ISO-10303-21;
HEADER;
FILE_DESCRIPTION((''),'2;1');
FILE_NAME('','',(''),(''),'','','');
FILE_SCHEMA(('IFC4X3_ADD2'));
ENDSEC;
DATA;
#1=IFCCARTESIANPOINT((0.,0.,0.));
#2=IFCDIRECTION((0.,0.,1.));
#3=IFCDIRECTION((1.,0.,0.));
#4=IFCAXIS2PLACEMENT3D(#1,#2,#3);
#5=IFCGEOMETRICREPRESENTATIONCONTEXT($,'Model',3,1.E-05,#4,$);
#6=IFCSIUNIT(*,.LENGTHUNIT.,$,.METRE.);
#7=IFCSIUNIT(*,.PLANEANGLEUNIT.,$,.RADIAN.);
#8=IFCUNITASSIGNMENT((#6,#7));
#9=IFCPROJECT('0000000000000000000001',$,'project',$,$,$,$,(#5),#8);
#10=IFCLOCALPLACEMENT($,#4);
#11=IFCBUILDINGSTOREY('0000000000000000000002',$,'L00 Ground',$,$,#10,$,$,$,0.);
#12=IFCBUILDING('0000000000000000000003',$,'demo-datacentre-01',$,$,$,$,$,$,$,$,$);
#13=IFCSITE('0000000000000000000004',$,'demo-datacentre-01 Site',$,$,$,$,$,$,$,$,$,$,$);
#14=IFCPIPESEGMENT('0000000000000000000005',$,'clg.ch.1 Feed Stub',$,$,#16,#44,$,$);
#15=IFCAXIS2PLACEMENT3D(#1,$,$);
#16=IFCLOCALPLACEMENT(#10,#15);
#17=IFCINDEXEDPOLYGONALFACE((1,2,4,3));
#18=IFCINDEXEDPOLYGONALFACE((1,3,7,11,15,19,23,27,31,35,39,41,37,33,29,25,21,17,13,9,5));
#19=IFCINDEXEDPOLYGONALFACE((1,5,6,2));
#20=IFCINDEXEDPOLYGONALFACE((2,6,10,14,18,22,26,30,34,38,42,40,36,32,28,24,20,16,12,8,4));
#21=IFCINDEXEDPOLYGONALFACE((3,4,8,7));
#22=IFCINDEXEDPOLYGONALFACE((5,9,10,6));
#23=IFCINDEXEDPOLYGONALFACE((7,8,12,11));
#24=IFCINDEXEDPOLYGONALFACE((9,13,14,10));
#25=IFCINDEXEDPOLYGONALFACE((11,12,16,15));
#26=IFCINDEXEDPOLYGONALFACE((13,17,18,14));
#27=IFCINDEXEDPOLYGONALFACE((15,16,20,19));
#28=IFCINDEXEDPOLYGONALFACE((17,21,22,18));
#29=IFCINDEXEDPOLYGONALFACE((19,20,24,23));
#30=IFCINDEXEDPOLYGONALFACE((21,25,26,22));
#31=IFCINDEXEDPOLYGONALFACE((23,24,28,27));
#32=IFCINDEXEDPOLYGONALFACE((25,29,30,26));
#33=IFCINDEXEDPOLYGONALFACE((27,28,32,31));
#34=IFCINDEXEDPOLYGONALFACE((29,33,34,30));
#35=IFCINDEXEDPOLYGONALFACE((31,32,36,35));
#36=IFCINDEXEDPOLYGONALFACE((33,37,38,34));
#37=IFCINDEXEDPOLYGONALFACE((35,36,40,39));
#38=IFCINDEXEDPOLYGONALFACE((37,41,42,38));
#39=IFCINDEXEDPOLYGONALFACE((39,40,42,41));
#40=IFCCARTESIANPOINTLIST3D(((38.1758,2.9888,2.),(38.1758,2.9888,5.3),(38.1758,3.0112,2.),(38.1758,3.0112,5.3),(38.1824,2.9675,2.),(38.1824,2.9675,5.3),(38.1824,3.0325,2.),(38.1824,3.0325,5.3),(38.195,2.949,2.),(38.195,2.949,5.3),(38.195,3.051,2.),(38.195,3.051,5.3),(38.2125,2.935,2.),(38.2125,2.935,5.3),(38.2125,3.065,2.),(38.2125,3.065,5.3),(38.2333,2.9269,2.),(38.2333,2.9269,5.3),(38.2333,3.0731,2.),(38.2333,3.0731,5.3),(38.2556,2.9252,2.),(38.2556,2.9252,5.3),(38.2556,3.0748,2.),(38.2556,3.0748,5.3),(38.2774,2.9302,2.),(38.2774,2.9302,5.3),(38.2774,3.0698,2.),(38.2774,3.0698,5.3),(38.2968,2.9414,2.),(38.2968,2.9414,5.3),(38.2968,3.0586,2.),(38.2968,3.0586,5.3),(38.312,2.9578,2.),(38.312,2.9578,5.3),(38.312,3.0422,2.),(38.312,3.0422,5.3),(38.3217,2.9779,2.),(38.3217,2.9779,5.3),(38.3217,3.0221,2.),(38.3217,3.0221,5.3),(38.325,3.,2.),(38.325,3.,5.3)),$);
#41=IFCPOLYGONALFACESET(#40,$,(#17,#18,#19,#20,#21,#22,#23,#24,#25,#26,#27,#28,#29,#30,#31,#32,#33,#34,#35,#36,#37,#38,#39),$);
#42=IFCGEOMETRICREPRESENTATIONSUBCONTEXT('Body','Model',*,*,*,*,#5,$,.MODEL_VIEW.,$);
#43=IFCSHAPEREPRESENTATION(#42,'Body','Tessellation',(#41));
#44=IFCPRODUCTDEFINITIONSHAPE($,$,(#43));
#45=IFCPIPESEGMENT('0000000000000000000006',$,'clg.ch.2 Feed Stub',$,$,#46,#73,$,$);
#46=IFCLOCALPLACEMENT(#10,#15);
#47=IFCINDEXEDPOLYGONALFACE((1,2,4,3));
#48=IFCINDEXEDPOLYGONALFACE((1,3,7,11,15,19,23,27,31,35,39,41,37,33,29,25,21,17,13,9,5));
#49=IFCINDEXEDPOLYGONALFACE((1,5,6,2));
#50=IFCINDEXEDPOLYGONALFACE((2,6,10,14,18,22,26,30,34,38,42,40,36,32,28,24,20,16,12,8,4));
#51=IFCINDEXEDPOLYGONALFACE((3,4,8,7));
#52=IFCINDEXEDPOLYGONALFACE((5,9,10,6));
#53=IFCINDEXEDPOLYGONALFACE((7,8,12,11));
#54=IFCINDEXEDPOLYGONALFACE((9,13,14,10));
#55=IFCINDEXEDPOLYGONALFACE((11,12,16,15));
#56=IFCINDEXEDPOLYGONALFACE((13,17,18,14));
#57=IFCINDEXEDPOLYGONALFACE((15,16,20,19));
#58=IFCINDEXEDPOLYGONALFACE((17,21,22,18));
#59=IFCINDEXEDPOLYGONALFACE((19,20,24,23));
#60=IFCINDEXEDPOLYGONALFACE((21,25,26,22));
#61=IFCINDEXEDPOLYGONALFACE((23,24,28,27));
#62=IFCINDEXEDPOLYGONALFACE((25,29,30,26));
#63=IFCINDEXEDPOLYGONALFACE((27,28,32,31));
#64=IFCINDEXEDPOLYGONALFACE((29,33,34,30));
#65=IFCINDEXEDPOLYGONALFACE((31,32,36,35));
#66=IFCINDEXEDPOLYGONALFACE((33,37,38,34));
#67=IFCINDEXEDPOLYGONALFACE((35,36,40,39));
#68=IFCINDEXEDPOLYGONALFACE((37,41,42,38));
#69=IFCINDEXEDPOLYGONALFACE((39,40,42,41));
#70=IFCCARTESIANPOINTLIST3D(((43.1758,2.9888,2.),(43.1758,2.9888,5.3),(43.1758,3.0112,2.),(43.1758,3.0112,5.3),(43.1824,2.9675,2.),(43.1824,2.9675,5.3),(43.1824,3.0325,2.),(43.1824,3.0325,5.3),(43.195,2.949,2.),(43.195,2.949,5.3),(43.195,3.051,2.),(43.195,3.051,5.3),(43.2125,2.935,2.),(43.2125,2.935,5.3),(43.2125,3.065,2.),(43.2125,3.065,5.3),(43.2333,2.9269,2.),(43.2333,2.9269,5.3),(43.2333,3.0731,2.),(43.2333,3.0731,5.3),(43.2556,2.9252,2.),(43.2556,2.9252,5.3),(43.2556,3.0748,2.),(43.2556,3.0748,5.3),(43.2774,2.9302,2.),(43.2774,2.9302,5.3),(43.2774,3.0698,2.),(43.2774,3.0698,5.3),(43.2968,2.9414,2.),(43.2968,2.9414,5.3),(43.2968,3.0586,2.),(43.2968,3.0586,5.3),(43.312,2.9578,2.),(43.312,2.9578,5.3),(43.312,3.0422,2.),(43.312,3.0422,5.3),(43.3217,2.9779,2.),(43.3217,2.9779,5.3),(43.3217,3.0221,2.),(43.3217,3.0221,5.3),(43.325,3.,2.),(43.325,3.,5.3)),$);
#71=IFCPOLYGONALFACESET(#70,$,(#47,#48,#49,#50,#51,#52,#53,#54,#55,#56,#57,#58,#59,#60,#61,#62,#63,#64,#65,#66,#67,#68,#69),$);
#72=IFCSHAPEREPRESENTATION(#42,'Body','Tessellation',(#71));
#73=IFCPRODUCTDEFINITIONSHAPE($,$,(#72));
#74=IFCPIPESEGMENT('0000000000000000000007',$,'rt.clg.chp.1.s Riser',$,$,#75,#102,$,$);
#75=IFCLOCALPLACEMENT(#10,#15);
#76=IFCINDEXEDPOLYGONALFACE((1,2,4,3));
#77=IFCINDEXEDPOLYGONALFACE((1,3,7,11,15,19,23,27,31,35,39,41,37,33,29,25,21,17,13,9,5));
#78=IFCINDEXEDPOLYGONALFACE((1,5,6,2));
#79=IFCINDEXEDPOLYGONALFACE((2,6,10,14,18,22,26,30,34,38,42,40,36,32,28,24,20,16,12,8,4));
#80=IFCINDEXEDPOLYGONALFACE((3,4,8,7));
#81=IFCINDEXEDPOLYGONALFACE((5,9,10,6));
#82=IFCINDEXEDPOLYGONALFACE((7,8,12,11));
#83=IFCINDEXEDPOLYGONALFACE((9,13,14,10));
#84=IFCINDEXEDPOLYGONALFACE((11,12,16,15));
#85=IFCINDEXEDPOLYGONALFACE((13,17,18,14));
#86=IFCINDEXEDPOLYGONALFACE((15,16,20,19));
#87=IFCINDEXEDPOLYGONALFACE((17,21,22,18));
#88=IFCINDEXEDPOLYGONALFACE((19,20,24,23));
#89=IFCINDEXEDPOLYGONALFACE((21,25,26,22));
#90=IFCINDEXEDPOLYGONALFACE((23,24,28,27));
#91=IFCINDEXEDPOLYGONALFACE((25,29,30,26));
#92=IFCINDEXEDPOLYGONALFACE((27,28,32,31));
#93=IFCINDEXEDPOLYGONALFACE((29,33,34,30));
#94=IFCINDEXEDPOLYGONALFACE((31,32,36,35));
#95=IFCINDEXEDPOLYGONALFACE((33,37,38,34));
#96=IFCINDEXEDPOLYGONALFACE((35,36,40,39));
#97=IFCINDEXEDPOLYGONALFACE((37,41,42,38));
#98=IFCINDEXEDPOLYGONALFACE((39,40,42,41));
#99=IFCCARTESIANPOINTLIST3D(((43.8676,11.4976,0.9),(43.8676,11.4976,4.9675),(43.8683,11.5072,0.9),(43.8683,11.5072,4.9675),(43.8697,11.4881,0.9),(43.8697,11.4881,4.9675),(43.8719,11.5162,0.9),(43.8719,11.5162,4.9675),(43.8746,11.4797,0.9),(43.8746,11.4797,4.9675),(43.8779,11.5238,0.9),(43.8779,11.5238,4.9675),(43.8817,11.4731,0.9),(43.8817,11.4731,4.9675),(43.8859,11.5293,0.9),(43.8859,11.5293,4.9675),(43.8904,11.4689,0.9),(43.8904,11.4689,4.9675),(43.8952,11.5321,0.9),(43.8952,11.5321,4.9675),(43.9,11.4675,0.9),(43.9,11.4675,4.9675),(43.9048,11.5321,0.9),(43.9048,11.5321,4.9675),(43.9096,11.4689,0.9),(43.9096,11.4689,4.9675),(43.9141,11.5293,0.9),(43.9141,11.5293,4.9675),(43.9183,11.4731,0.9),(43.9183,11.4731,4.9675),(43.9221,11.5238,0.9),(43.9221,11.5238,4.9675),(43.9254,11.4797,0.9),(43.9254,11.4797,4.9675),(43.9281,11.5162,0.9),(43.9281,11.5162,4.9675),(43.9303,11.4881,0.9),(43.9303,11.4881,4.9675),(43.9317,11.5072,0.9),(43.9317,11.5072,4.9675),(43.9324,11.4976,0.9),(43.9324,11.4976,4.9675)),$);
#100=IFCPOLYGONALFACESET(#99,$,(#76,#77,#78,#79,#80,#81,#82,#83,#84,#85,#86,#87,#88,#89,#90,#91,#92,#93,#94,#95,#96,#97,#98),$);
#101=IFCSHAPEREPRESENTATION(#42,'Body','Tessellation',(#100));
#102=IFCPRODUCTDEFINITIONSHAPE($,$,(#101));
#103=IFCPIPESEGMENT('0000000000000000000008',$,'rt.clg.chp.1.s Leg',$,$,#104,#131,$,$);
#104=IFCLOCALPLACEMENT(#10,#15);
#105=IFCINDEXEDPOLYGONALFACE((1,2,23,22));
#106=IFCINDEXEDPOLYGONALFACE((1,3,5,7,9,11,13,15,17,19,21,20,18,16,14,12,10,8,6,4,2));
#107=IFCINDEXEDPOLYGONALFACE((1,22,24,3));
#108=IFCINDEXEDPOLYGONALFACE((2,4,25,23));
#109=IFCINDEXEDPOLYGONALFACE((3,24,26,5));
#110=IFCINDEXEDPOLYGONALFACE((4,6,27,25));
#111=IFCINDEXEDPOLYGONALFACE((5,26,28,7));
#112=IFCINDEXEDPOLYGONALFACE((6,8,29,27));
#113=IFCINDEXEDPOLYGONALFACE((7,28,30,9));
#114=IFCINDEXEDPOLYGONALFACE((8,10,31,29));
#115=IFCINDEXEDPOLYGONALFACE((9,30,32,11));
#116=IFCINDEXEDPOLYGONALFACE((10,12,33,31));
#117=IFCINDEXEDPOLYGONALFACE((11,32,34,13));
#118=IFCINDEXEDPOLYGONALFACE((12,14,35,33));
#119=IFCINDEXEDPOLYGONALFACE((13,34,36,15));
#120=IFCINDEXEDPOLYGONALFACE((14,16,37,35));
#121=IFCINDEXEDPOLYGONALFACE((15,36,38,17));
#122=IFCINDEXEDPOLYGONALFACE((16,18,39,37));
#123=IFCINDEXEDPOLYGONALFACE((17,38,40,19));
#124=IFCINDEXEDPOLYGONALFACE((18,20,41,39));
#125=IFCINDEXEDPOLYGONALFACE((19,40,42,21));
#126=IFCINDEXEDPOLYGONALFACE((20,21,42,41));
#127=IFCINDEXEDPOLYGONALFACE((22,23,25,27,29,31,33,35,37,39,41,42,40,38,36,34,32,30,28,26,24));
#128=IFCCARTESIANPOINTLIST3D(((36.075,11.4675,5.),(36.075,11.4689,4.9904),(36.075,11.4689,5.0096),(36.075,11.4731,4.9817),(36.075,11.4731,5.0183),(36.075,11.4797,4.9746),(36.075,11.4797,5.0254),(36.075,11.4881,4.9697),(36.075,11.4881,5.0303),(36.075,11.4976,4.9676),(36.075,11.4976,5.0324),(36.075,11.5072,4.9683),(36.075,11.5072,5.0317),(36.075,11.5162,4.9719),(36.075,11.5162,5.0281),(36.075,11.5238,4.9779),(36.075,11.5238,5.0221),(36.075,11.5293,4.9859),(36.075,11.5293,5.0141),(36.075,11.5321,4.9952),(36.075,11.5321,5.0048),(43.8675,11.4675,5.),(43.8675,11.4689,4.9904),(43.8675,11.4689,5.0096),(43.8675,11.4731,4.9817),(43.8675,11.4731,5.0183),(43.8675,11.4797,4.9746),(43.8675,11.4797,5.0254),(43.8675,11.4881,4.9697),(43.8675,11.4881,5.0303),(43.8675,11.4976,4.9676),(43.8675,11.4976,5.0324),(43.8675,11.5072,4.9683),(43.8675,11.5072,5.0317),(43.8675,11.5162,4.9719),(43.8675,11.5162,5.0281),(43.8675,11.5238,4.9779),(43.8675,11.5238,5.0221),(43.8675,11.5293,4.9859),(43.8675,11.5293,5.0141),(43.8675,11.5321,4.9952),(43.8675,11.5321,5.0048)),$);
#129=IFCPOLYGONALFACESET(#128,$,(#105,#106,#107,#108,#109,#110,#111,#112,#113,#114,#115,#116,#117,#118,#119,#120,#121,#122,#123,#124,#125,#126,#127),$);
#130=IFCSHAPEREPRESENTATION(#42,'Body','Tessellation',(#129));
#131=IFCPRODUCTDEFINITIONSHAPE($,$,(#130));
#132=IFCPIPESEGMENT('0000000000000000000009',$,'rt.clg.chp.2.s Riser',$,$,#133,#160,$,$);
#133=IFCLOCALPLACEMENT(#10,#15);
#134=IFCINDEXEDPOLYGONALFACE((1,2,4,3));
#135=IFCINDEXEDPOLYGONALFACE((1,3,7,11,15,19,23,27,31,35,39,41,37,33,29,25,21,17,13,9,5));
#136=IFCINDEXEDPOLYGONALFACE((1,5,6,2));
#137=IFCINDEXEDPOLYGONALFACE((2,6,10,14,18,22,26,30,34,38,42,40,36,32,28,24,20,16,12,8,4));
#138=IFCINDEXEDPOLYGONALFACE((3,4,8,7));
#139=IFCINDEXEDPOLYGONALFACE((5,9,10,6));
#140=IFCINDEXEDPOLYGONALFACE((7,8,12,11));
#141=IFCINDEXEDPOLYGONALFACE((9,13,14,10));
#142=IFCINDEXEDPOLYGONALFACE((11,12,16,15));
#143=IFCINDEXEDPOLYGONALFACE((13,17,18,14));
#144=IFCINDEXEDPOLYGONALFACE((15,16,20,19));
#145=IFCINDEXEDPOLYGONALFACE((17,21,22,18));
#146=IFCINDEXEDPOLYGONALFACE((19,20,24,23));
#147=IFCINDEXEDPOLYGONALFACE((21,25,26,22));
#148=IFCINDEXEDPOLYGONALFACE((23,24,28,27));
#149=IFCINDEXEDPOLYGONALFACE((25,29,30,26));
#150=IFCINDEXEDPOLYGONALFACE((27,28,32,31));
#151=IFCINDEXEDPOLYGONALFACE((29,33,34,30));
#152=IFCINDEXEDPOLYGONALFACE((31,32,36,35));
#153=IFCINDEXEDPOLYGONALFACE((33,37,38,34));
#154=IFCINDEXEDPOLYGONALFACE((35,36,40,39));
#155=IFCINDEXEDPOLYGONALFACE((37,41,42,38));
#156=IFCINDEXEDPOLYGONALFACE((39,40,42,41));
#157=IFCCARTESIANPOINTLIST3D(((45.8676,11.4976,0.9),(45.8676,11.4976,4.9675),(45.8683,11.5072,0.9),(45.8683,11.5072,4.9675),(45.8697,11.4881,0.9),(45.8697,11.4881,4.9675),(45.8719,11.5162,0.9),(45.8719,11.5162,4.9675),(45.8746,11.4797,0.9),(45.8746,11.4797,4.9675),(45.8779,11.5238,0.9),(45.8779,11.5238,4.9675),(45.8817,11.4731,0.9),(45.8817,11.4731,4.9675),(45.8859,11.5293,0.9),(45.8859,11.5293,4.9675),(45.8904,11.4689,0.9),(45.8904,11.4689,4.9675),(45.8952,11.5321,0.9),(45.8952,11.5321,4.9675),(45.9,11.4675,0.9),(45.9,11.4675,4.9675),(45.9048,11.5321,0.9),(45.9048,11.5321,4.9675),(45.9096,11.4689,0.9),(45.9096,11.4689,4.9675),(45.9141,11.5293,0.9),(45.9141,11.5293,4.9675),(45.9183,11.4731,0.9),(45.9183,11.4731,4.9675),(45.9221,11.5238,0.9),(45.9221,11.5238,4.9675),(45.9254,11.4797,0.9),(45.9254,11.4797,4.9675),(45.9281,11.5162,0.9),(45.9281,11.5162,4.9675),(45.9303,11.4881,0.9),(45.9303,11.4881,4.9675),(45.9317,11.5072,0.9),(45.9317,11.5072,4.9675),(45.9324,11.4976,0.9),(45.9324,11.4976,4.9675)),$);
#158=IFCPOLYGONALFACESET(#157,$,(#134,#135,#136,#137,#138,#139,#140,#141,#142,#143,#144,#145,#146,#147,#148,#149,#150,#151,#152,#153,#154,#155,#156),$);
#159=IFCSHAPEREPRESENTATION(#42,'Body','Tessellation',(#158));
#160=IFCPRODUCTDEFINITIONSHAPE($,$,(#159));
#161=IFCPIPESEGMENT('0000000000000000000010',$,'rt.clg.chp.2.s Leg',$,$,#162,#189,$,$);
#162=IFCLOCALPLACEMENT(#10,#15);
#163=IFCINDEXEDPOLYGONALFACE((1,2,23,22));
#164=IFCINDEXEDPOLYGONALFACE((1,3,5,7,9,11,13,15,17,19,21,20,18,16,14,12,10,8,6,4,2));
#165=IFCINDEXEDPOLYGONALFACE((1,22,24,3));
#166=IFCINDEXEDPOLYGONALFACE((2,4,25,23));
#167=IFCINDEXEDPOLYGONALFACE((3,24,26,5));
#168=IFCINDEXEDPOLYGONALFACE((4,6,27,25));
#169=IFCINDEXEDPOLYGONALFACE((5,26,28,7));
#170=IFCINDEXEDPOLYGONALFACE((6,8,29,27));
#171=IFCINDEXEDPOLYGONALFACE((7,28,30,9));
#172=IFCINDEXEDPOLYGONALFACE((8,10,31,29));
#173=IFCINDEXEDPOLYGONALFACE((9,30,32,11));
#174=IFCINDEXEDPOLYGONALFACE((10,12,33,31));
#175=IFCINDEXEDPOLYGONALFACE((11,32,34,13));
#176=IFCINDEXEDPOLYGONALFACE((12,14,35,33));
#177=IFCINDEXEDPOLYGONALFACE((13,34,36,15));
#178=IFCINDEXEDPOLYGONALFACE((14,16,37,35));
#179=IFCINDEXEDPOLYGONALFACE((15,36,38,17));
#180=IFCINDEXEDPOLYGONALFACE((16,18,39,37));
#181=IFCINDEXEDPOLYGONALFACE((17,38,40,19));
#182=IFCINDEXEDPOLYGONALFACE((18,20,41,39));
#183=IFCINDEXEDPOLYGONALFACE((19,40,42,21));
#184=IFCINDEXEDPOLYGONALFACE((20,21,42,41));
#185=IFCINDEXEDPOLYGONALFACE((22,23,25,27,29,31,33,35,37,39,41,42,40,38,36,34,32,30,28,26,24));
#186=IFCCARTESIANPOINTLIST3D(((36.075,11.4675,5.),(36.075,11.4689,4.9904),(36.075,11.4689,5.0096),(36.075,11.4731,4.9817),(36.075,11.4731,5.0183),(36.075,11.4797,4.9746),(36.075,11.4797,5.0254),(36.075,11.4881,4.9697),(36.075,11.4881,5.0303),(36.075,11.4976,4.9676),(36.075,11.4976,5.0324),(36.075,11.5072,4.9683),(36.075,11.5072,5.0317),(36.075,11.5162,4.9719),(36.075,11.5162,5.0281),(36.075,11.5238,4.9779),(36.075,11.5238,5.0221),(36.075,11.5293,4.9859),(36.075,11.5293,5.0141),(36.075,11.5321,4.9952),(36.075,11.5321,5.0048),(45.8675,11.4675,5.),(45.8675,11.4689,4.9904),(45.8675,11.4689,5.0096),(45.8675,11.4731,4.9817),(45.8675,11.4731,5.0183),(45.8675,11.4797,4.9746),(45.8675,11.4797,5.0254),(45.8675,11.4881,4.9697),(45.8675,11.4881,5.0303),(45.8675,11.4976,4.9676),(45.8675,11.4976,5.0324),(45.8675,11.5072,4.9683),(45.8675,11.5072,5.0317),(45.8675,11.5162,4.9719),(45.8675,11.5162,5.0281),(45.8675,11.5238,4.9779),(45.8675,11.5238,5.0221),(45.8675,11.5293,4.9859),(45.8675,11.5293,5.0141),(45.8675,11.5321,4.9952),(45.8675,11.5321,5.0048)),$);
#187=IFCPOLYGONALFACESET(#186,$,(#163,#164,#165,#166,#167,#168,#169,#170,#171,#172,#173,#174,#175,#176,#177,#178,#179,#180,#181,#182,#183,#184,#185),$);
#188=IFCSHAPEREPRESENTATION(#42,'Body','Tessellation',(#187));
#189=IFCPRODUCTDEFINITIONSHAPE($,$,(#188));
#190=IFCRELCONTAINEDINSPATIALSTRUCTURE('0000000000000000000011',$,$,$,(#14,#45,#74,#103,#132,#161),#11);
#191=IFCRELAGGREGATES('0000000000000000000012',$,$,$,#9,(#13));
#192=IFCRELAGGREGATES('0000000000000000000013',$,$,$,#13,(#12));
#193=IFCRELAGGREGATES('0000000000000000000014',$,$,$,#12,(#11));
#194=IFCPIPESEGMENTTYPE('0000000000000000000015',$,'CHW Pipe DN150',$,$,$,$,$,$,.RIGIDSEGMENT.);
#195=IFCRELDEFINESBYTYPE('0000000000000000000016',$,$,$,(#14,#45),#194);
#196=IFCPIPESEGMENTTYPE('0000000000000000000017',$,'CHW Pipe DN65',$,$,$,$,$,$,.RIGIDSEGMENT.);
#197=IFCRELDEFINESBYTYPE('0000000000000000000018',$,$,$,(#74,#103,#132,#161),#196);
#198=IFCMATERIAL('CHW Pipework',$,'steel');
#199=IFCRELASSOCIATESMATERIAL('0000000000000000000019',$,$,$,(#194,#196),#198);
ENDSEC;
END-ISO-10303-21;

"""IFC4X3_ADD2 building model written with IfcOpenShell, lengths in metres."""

from ifc_helpers import new_model, si_unit, frame, origin_with_axes, place, context, subcontext, project, spatial, circle, extrude, material, type_object, element, save


model = new_model("IFC4X3_ADD2")

# Units and contexts
model_context = context("Model", 3, precision=1e-05, world=origin_with_axes())
body_context = subcontext(model_context, "Body", "Model", "MODEL_VIEW")
ifc_project = project(units=[si_unit("LENGTHUNIT", "METRE"), si_unit("PLANEANGLEUNIT", "RADIAN")], contexts=[model_context])

# Site, building, storey
site = spatial("IfcSite", under=ifc_project, Name="demo-datacentre-01 Site")
building = spatial("IfcBuilding", under=site, Name="demo-datacentre-01")
storey_placement = place(None, origin_with_axes())
storey = spatial("IfcBuildingStorey", under=building, at=storey_placement, Name="L00 Ground", Elevation=0.0)

# Shared definitions
ifc_material = material(Name="CHW Pipework", Category="steel")

# Pipe segments
pipe_segment_type_1 = type_object("IfcPipeSegmentType", Name="CHW Pipe DN150", PredefinedType="RIGIDSEGMENT", material=ifc_material)
for number, where, z_axis, x_axis, name in (
    (1, (38.25, 3.0, 5.3), (0.0, 0.0, -1.0), (1.0, 0.0, 0.0), "clg.ch.1 Feed Stub"),
    (2, (43.25, 3.0, 5.3), (0.0, 0.0, -1.0), (1.0, 0.0, 0.0), "clg.ch.2 Feed Stub"),
):
    element("IfcPipeSegment", number, at=place(storey_placement, frame(where, z_axis=z_axis, x_axis=x_axis)), inside=storey, type_object=pipe_segment_type_1, Name=name, context=body_context, shape_type="SweptSolid", body=[
        extrude(circle(Radius=0.075), origin_with_axes(), (0.0, 0.0, 1.0), 3.3),
    ])
pipe_segment_type_2 = type_object("IfcPipeSegmentType", Name="CHW Pipe DN65", PredefinedType="RIGIDSEGMENT", material=ifc_material)
pipe_segment_1_placement = place(storey_placement, frame((43.9, 11.5, 0.9), z_axis=(0.0, 0.0, 1.0), x_axis=(0.0, -1.0, 0.0)))
element("IfcPipeSegment", 3, at=pipe_segment_1_placement, inside=storey, type_object=pipe_segment_type_2, Name="rt.clg.chp.1.s Riser", context=body_context, shape_type="SweptSolid", body=[
    extrude(circle(Radius=0.0325), origin_with_axes(), (0.0, 0.0, 1.0), 4.0675),
])
pipe_segment_2_placement = place(storey_placement, frame((43.8675, 11.5, 5.0), z_axis=(-1.0, 0.0, 0.0), x_axis=(0.0, -1.0, 0.0)))
element("IfcPipeSegment", 4, at=pipe_segment_2_placement, inside=storey, type_object=pipe_segment_type_2, Name="rt.clg.chp.1.s Leg", context=body_context, shape_type="SweptSolid", body=[
    extrude(circle(Radius=0.0325), origin_with_axes(), (0.0, 0.0, 1.0), 7.7925),
])
pipe_segment_3_placement = place(storey_placement, frame((45.9, 11.5, 0.9), z_axis=(0.0, 0.0, 1.0), x_axis=(0.0, -1.0, 0.0)))
element("IfcPipeSegment", 5, at=pipe_segment_3_placement, inside=storey, type_object=pipe_segment_type_2, Name="rt.clg.chp.2.s Riser", context=body_context, shape_type="SweptSolid", body=[
    extrude(circle(Radius=0.0325), origin_with_axes(), (0.0, 0.0, 1.0), 4.0675),
])
pipe_segment_4_placement = place(storey_placement, frame((45.8675, 11.5, 5.0), z_axis=(-1.0, 0.0, 0.0), x_axis=(0.0, -1.0, 0.0)))
element("IfcPipeSegment", 6, at=pipe_segment_4_placement, inside=storey, type_object=pipe_segment_type_2, Name="rt.clg.chp.2.s Leg", context=body_context, shape_type="SweptSolid", body=[
    extrude(circle(Radius=0.0325), origin_with_axes(), (0.0, 0.0, 1.0), 9.7925),
])

save(model, "model.ifc")
